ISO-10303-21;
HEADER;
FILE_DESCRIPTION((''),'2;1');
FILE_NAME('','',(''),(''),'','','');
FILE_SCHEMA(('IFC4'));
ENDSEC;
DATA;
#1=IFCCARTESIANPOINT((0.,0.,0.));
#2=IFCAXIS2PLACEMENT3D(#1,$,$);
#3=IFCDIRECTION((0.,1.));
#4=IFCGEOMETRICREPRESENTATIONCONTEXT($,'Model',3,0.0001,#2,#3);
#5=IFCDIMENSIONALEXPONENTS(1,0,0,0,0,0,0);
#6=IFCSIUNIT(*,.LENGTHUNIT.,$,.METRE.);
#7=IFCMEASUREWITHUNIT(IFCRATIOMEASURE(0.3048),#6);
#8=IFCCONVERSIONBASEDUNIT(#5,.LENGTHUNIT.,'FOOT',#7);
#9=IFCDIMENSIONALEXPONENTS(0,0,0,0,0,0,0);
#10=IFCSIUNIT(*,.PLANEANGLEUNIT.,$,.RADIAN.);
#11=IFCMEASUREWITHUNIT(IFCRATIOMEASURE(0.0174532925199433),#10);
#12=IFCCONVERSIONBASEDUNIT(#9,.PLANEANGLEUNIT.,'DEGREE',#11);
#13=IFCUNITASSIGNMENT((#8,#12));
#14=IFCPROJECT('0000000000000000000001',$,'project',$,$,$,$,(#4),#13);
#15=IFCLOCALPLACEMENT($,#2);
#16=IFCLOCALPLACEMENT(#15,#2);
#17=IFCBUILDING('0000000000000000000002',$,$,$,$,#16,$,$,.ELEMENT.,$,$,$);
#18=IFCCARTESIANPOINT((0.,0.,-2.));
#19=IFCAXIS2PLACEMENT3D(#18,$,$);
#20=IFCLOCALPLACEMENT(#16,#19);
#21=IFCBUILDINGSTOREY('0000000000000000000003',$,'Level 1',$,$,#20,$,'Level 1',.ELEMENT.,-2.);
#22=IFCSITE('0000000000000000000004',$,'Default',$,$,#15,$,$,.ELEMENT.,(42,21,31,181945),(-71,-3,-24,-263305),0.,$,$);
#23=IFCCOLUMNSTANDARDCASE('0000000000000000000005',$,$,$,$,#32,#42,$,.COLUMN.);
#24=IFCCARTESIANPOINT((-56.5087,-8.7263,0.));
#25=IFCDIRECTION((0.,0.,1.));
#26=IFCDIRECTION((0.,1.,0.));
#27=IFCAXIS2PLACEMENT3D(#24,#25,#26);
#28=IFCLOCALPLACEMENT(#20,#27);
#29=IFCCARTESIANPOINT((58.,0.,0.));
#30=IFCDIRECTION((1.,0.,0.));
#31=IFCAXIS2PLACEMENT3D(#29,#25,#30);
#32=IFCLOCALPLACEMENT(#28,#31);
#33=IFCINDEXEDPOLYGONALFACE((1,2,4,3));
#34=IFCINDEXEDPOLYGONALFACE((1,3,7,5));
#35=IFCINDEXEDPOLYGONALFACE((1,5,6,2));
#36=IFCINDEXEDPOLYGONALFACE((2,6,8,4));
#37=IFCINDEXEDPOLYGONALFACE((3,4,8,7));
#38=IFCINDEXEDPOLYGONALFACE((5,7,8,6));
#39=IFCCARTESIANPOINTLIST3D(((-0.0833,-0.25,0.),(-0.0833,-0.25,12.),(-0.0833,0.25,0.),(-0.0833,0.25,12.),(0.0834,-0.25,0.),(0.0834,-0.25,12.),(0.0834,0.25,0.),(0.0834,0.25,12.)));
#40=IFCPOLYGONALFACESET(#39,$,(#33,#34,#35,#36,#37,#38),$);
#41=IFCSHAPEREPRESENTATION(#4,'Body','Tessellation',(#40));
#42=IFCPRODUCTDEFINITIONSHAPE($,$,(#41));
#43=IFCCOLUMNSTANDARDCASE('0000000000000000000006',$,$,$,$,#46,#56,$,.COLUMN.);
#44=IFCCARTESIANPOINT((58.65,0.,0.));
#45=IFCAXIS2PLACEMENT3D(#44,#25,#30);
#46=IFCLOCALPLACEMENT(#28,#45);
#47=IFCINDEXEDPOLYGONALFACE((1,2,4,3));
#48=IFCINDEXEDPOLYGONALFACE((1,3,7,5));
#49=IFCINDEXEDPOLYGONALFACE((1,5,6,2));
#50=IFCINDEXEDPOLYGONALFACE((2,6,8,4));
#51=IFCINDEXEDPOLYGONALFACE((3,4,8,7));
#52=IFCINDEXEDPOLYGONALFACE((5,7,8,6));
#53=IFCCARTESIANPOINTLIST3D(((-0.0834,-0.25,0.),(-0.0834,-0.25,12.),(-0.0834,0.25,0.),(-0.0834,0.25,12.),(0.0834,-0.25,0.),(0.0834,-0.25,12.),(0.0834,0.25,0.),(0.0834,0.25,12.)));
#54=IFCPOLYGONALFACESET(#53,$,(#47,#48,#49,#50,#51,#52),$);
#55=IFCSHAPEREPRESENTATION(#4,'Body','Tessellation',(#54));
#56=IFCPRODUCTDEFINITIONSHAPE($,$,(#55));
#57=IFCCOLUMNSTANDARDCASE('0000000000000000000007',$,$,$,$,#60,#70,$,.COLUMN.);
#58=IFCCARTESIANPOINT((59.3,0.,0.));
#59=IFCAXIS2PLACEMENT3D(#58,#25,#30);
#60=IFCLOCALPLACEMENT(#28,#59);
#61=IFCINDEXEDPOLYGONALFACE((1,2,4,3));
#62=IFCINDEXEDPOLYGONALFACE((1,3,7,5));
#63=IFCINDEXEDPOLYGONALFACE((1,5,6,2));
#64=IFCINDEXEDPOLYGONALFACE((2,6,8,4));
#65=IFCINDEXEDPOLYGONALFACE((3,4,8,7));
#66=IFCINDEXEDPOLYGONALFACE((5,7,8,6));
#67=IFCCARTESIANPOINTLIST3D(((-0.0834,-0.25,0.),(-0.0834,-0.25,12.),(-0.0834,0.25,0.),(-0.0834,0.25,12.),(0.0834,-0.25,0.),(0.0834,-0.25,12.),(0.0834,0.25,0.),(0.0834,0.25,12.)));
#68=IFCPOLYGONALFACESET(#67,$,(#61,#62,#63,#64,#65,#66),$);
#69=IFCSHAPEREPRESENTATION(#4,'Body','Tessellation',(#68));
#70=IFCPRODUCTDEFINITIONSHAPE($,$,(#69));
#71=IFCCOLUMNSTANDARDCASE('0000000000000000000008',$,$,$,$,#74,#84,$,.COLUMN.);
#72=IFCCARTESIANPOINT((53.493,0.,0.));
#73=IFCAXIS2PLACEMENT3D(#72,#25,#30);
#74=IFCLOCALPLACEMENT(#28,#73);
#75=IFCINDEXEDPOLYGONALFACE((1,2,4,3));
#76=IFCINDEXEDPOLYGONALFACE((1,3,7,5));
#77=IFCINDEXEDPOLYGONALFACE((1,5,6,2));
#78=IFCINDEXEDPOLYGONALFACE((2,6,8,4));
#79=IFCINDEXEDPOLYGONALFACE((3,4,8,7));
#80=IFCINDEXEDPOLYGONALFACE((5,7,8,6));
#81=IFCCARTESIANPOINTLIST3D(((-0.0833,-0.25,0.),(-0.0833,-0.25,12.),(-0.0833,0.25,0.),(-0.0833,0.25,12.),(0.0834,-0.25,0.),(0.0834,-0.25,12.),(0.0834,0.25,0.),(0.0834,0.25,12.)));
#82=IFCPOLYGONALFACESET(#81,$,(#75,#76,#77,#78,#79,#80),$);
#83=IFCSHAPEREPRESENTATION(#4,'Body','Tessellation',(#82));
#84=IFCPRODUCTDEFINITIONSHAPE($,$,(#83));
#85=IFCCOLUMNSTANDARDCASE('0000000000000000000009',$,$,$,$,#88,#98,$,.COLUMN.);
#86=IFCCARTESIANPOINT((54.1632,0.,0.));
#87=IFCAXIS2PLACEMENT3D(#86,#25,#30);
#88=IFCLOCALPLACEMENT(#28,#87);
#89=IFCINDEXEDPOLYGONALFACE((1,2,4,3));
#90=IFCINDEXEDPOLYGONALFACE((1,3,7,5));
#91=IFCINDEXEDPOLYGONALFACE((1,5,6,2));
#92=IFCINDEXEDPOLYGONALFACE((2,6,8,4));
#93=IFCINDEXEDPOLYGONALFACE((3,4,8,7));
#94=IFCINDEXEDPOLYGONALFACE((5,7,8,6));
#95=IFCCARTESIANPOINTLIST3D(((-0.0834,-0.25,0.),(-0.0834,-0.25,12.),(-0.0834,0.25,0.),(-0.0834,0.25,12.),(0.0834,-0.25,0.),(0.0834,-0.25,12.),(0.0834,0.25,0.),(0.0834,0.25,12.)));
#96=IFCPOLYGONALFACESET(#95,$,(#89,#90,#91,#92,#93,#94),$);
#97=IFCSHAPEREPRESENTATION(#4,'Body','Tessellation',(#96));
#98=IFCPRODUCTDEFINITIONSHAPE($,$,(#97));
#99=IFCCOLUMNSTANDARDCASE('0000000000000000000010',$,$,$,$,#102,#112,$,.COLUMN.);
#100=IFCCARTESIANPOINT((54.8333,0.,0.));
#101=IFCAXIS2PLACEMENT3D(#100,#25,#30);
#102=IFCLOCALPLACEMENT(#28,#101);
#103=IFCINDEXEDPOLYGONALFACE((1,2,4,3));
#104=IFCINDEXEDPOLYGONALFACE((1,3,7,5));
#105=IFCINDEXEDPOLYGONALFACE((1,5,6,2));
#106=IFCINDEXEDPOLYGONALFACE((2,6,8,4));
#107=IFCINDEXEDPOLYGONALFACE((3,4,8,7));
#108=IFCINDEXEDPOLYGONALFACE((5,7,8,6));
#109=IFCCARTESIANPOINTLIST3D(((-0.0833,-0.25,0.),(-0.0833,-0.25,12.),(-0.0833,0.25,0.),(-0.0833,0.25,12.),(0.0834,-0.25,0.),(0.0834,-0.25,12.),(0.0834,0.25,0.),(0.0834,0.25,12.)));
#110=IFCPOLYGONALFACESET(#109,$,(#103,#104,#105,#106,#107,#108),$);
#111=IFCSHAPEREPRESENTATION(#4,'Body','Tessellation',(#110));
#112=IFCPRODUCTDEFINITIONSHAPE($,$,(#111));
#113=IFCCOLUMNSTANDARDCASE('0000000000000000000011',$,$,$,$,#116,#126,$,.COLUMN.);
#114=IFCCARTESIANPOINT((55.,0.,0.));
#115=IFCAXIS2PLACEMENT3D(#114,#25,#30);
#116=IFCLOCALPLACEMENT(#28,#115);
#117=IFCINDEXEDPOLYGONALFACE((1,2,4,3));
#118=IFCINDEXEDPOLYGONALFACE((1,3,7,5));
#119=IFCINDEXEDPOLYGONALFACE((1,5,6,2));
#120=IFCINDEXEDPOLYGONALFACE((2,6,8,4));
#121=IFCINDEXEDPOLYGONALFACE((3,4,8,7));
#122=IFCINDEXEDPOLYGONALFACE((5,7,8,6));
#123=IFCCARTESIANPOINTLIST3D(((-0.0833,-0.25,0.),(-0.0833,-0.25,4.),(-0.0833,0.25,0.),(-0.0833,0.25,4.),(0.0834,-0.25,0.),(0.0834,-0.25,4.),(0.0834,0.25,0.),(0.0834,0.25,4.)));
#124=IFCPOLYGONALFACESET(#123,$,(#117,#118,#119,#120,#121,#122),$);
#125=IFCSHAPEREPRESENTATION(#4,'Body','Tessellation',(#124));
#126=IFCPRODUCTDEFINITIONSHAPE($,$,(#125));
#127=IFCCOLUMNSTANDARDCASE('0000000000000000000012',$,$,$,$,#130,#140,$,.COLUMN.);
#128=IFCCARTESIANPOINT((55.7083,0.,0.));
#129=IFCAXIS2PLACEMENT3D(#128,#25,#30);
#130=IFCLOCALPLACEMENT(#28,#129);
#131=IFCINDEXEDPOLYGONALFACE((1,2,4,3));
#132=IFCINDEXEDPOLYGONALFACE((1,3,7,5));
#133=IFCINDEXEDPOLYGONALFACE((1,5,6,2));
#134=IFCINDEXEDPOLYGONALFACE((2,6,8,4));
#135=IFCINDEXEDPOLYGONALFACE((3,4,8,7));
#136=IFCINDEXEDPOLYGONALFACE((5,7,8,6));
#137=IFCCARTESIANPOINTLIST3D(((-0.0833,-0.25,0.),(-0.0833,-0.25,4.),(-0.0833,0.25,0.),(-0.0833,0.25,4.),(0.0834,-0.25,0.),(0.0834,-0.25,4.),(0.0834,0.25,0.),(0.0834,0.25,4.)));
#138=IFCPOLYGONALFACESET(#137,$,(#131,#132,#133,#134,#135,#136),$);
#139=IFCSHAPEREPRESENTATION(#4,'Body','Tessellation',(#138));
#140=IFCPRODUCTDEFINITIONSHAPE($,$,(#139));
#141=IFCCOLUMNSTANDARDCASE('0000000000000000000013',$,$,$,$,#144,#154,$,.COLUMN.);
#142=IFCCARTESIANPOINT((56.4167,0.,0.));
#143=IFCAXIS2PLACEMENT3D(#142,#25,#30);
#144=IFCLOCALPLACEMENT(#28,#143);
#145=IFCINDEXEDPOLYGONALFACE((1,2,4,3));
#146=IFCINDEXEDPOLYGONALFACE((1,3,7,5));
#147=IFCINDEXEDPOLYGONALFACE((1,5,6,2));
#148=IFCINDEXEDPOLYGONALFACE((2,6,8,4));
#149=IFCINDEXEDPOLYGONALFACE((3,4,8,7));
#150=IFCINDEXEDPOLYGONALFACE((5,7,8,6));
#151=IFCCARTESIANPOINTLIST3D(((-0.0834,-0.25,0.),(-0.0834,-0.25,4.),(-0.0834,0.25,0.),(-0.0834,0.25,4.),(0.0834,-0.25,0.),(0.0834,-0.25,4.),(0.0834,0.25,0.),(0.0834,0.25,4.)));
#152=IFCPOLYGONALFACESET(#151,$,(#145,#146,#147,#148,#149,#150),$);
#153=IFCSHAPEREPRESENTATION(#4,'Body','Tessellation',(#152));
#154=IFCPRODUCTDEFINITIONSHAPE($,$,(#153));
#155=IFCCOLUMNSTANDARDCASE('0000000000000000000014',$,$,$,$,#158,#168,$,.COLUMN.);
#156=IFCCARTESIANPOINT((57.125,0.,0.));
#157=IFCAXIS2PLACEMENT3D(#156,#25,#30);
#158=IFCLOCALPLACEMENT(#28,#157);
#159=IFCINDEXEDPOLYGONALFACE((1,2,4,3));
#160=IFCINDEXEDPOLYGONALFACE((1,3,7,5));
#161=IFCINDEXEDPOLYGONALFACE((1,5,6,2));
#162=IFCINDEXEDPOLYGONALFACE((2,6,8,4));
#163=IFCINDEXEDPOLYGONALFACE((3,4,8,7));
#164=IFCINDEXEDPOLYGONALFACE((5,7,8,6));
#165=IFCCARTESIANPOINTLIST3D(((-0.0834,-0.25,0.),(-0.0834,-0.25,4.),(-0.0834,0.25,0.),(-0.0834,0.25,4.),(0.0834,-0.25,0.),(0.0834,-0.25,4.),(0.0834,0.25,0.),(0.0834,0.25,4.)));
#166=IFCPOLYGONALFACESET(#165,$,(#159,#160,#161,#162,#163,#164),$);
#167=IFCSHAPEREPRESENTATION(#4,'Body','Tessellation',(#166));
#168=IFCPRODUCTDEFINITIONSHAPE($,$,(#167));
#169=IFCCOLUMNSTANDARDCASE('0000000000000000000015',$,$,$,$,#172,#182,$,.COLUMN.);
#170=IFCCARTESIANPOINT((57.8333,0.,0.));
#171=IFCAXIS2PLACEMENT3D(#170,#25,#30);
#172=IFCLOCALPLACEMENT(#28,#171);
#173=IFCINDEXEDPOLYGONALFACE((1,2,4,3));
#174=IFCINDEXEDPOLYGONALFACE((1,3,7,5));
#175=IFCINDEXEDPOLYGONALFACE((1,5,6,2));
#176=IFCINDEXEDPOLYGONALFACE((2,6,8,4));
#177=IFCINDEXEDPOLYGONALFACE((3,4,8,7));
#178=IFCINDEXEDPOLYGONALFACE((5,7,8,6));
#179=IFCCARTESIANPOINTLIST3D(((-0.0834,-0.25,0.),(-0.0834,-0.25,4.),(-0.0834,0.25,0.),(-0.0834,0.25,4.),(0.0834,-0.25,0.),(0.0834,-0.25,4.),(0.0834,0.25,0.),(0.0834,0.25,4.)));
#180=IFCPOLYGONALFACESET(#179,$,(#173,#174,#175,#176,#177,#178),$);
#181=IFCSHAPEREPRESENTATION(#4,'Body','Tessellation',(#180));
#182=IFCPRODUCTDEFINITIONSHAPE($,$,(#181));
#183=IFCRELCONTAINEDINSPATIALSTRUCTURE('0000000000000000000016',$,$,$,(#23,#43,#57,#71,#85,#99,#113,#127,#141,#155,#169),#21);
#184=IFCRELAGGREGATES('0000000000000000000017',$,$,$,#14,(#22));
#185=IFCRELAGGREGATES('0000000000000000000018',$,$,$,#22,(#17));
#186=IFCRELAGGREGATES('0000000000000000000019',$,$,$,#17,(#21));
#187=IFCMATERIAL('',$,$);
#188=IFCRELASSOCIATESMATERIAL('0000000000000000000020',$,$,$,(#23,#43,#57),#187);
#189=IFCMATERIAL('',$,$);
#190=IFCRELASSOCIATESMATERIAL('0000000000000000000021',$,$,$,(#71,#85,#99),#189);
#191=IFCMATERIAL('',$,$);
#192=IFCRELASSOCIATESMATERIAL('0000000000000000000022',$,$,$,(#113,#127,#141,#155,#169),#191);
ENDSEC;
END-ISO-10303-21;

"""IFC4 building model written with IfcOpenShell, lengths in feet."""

from ifc_helpers import new_model, entity, si_unit, converted_unit, direction, frame, origin, place, context, project, spatial, rectangle, extrude, material, element, save


model = new_model("IFC4")

# Units and contexts
model_context = context("Model", 3, precision=0.0001, world=origin(), true_north=direction((0.0, 1.0)))
ifc_project = project(units=[converted_unit("LENGTHUNIT", "FOOT", entity("IfcRatioMeasure", 0.3048), si_unit("LENGTHUNIT", "METRE"), dimensions=[1, 0, 0, 0, 0, 0, 0]), converted_unit("PLANEANGLEUNIT", "DEGREE", entity("IfcRatioMeasure", 0.0174532925199433), si_unit("PLANEANGLEUNIT", "RADIAN"), dimensions=[0, 0, 0, 0, 0, 0, 0])], contexts=[model_context])

# Site, building, storey
site_placement = place(None, origin())
site = spatial("IfcSite", under=ifc_project, at=site_placement, Name="Default", CompositionType="ELEMENT", RefLatitude=(42, 21, 31, 181945), RefLongitude=(-71, -3, -24, -263305), RefElevation=0.0)
building_placement = place(site_placement, origin())
building = spatial("IfcBuilding", under=site, at=building_placement, CompositionType="ELEMENT")
storey_placement = place(building_placement, frame((0.0, 0.0, -2.0)))
storey = spatial("IfcBuildingStorey", under=building, at=storey_placement, Name="Level 1", LongName="Level 1", CompositionType="ELEMENT", Elevation=-2.0)

# Columns
ifc_material_1 = material(Name="")
placement = place(storey_placement, frame((-56.5087, -8.7263, 0.0), z_axis=(0.0, 0.0, 1.0), x_axis=(0.0, 1.0, 0.0)))
for number, where, z_axis, x_axis in (
    (1, (58.0, 0.0, 0.0), (0.0, 0.0, 1.0), (1.0, 0.0, 0.0)),
    (2, (58.65, 0.0, 0.0), (0.0, 0.0, 1.0), (1.0, 0.0, 0.0)),
    (3, (59.3, 0.0, 0.0), (0.0, 0.0, 1.0), (1.0, 0.0, 0.0)),
):
    element("IfcColumnStandardCase", number, at=place(placement, frame(where, z_axis=z_axis, x_axis=x_axis)), inside=storey, material=ifc_material_1, PredefinedType="COLUMN", context=model_context, shape_type="SweptSolid", body=[
        extrude(rectangle(XDim=0.1667, YDim=0.5), origin(), (0.0, 0.0, 1.0), 12.0),
    ])
ifc_material_2 = material(Name="")
for number, where, z_axis, x_axis in (
    (4, (53.493, 0.0, 0.0), (0.0, 0.0, 1.0), (1.0, 0.0, 0.0)),
    (5, (54.1632, 0.0, 0.0), (0.0, 0.0, 1.0), (1.0, 0.0, 0.0)),
    (6, (54.8333, 0.0, 0.0), (0.0, 0.0, 1.0), (1.0, 0.0, 0.0)),
):
    element("IfcColumnStandardCase", number, at=place(placement, frame(where, z_axis=z_axis, x_axis=x_axis)), inside=storey, material=ifc_material_2, PredefinedType="COLUMN", context=model_context, shape_type="SweptSolid", body=[
        extrude(rectangle(XDim=0.1667, YDim=0.5), origin(), (0.0, 0.0, 1.0), 12.0),
    ])
ifc_material_3 = material(Name="")
for number, where, z_axis, x_axis in (
    (7, (55.0, 0.0, 0.0), (0.0, 0.0, 1.0), (1.0, 0.0, 0.0)),
    (8, (55.7083, 0.0, 0.0), (0.0, 0.0, 1.0), (1.0, 0.0, 0.0)),
    (9, (56.4167, 0.0, 0.0), (0.0, 0.0, 1.0), (1.0, 0.0, 0.0)),
    (10, (57.125, 0.0, 0.0), (0.0, 0.0, 1.0), (1.0, 0.0, 0.0)),
    (11, (57.8333, 0.0, 0.0), (0.0, 0.0, 1.0), (1.0, 0.0, 0.0)),
):
    element("IfcColumnStandardCase", number, at=place(placement, frame(where, z_axis=z_axis, x_axis=x_axis)), inside=storey, material=ifc_material_3, PredefinedType="COLUMN", context=model_context, shape_type="SweptSolid", body=[
        extrude(rectangle(XDim=0.1667, YDim=0.5), origin(), (0.0, 0.0, 1.0), 4.0),
    ])

save(model, "model.ifc")
